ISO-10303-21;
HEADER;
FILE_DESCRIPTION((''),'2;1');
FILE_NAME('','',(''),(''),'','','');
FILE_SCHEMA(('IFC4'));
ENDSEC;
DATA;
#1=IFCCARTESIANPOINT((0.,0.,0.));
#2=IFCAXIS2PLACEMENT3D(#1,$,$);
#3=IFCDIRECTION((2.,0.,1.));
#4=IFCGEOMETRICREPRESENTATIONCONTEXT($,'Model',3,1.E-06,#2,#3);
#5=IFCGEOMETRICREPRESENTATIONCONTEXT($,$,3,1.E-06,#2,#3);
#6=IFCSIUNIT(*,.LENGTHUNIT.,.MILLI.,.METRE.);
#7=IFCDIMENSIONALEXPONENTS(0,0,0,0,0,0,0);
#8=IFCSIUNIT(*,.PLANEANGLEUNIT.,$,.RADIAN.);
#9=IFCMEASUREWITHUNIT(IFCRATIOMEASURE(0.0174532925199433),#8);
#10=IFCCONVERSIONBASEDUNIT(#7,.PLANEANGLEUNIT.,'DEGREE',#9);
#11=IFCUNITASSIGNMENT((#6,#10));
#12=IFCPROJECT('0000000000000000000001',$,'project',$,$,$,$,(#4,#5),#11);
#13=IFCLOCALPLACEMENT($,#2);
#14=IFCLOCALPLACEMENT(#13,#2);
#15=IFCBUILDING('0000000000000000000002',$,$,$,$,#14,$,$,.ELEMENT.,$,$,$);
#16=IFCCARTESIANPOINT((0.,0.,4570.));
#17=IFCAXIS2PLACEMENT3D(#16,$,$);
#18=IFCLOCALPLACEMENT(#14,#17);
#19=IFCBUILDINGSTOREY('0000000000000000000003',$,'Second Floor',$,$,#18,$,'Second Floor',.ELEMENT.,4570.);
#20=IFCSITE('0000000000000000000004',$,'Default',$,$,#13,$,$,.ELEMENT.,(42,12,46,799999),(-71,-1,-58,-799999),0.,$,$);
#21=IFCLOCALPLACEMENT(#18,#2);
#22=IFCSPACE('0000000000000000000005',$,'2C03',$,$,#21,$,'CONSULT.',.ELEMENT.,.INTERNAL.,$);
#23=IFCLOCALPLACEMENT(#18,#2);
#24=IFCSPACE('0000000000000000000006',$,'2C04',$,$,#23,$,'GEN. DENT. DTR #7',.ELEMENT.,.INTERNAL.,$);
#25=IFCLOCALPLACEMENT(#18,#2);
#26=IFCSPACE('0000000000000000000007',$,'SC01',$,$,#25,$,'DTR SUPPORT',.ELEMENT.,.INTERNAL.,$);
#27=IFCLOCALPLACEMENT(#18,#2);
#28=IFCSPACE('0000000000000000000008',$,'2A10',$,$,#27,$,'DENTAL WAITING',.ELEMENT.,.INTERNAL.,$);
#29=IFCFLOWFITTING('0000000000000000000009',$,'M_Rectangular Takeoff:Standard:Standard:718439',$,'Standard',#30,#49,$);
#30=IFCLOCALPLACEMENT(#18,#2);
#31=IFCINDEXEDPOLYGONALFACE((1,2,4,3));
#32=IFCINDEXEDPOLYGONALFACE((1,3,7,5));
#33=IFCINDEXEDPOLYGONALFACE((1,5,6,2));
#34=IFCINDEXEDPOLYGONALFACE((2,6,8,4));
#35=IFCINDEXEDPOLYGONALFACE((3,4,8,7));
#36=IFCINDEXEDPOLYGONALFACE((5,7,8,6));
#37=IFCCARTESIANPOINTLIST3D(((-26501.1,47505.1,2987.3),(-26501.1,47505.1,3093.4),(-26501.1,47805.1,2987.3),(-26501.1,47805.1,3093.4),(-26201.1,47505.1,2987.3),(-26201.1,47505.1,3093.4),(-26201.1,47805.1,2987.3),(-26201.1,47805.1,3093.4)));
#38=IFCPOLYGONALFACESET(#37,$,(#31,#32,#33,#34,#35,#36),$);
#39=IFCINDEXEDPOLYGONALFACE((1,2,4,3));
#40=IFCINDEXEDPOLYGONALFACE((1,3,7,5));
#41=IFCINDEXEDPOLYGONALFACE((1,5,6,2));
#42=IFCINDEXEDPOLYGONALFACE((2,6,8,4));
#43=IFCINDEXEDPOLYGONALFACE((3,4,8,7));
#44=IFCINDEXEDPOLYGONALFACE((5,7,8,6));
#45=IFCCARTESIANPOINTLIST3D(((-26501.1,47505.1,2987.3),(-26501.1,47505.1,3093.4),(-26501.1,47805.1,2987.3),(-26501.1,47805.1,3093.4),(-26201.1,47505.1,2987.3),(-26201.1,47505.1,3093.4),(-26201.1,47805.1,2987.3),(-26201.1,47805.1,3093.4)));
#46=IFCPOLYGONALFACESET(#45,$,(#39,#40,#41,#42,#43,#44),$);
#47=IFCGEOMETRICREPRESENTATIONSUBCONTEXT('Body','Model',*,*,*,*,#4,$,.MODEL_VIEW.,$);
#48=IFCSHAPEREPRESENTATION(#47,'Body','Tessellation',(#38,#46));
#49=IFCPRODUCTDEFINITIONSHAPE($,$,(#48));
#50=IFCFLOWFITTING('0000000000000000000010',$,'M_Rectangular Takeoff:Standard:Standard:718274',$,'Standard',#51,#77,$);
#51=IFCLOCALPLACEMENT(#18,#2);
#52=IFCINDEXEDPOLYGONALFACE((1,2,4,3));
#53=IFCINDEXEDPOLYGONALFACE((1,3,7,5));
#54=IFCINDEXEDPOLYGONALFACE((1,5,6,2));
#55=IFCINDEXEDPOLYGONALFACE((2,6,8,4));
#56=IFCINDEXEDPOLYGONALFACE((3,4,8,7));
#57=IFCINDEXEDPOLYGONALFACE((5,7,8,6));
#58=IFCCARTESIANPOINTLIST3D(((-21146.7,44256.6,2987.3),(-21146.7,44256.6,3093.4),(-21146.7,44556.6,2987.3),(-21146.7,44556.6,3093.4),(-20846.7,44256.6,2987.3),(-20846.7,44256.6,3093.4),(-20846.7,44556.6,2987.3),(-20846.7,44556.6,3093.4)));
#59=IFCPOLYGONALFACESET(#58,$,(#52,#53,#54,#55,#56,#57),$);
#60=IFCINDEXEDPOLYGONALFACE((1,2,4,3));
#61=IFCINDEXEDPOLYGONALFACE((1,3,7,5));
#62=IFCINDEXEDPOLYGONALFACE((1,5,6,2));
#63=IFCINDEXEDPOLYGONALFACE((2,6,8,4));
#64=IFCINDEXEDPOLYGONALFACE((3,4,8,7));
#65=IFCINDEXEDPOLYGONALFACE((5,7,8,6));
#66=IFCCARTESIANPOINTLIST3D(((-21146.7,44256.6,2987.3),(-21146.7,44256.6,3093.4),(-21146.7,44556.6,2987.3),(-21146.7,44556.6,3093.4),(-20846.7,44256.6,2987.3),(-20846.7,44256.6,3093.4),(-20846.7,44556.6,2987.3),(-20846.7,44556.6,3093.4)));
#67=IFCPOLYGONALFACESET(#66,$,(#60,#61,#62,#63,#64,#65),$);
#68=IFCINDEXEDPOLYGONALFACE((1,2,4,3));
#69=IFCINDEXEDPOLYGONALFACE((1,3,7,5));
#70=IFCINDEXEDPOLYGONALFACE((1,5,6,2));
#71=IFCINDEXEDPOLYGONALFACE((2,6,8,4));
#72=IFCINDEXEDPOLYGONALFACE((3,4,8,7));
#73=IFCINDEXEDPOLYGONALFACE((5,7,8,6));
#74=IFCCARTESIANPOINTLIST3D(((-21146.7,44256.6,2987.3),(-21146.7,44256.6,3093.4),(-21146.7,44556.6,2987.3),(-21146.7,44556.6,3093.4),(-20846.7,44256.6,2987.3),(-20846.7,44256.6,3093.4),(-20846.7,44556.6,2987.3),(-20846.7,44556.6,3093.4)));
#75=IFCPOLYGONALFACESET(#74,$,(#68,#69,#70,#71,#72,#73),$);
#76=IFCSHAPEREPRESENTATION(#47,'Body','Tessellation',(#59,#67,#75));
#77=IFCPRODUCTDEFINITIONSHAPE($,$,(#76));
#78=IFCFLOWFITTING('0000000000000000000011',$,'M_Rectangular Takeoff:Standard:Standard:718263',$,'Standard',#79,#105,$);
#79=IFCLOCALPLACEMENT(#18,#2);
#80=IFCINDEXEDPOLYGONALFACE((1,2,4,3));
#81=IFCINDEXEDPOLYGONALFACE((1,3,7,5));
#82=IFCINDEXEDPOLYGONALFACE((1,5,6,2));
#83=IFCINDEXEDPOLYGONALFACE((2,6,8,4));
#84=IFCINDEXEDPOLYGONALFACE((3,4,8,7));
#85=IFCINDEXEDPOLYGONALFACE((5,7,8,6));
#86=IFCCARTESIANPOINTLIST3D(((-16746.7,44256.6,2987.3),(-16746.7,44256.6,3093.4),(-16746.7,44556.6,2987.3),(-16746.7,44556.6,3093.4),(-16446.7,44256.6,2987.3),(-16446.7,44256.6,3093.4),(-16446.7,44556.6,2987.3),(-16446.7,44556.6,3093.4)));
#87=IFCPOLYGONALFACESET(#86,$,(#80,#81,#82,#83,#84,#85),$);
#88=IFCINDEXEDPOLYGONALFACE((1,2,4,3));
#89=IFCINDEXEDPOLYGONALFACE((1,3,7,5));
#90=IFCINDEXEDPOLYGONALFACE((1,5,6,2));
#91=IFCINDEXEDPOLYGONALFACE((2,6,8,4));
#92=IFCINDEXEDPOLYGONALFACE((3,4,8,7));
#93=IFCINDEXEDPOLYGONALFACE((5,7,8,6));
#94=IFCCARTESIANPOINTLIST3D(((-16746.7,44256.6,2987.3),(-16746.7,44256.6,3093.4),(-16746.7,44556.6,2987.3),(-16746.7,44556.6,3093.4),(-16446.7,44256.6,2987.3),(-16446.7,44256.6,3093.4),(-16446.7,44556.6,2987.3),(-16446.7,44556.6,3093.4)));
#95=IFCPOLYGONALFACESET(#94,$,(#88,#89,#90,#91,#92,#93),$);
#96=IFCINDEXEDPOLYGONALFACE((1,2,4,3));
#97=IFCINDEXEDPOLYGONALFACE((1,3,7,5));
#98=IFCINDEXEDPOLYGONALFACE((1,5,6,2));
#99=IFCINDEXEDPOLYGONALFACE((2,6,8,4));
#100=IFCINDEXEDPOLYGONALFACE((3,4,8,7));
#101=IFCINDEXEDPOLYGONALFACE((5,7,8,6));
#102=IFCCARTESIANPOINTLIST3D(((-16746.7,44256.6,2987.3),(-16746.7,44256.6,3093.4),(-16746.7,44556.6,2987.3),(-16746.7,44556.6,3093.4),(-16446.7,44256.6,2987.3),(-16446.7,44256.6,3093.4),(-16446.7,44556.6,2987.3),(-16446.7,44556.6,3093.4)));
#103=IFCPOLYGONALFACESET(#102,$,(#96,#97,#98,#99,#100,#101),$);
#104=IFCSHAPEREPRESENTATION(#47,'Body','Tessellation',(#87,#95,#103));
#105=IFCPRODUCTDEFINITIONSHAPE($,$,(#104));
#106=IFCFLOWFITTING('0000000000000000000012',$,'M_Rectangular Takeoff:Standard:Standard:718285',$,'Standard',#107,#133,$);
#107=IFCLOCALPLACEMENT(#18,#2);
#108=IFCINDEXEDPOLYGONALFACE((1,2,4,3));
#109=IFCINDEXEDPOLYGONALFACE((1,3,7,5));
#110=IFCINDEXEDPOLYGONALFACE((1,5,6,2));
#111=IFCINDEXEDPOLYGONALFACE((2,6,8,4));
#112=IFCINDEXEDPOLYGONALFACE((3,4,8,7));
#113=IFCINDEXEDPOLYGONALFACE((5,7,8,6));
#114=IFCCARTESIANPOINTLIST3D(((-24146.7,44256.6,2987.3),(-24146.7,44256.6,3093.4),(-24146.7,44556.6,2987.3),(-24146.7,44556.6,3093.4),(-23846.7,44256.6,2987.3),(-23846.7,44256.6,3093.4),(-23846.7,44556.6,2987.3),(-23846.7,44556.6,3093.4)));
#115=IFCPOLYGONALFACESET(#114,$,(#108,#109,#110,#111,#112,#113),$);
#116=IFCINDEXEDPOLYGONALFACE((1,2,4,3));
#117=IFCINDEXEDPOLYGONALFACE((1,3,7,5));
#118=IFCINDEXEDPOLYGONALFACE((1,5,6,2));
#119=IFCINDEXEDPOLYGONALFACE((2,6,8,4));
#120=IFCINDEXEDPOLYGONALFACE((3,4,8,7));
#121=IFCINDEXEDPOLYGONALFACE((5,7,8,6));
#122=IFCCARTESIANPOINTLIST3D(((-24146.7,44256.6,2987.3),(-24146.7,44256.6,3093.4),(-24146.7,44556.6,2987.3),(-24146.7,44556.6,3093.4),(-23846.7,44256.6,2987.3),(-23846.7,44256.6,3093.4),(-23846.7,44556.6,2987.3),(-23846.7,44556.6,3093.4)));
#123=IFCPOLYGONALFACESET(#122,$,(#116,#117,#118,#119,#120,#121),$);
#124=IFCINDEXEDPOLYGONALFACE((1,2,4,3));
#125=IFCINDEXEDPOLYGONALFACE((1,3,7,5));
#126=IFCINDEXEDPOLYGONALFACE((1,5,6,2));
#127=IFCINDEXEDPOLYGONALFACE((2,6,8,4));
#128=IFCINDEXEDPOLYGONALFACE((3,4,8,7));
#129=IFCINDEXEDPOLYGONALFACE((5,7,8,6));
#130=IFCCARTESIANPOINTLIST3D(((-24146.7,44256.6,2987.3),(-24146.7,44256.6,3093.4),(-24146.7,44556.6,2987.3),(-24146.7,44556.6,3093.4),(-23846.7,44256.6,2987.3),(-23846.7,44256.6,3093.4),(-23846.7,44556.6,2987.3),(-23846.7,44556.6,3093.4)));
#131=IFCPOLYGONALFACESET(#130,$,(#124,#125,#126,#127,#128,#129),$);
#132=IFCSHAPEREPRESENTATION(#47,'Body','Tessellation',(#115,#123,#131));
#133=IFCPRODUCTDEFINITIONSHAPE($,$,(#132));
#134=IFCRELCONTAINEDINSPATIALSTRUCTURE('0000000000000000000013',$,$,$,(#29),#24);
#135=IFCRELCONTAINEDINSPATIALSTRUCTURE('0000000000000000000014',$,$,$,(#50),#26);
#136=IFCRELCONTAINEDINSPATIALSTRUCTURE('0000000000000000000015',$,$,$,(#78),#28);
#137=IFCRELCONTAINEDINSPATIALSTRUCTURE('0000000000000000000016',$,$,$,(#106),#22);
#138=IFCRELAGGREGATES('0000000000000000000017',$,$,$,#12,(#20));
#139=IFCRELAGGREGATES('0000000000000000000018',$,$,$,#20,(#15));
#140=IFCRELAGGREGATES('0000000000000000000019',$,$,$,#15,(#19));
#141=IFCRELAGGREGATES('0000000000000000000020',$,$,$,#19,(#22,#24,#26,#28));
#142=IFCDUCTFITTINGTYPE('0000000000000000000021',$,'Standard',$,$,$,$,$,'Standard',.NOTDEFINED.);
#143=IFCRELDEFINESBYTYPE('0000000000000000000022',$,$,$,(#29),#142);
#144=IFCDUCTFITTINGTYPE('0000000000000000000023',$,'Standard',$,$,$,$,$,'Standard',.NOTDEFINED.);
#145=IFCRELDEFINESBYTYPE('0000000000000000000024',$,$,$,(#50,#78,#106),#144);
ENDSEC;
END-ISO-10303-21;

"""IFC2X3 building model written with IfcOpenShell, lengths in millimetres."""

from ifc_helpers import new_model, entity, si_unit, converted_unit, direction, frame, frame_2d, origin, place, context, subcontext, project, spatial, rectangle, extrude, source, transform, mapped, type_object, type_shapes, element, save


model = new_model("IFC2X3")

# Units and contexts
model_context = context("Model", 3, precision=1e-06, world=origin(), true_north=direction((2.0, 0.0, 1.0)))
context_of_model = context(None, 3, precision=1e-06, world=origin(), true_north=direction((2.0, 0.0, 1.0)))
body_context = subcontext(model_context, "Body", "Model", "MODEL_VIEW")
ifc_project = project(units=[si_unit("LENGTHUNIT", "METRE", prefix="MILLI"), converted_unit("PLANEANGLEUNIT", "DEGREE", entity("IfcRatioMeasure", 0.0174532925199433), si_unit("PLANEANGLEUNIT", "RADIAN"), dimensions=[0, 0, 0, 0, 0, 0, 0])], contexts=[model_context, context_of_model])

# Site, building, storey
site_placement = place(None, origin())
site = spatial("IfcSite", under=ifc_project, at=site_placement, Name="Default", CompositionType="ELEMENT", RefLatitude=(42, 12, 46, 799999), RefLongitude=(-71, -1, -58, -799999), RefElevation=0.0)
building_placement = place(site_placement, origin())
building = spatial("IfcBuilding", under=site, at=building_placement, CompositionType="ELEMENT")
storey_placement = place(building_placement, frame((0.0, 0.0, 4570.0)))
storey = spatial("IfcBuildingStorey", under=building, at=storey_placement, Name="Second Floor", LongName="Second Floor", CompositionType="ELEMENT", Elevation=4570.0)

# Shared definitions
space_1_placement = place(storey_placement, origin())
space_1 = spatial("IfcSpace", under=storey, at=space_1_placement, Name="2C03", LongName="CONSULT.", CompositionType="ELEMENT", InteriorOrExteriorSpace="INTERNAL")

# Shared definitions
duct_fitting_type_1 = type_object("IfcDuctFittingType", Name="Standard", ElementType="Standard", PredefinedType="NOTDEFINED")
shared_shape_1 = source(origin(), body_context, "Body", "SweptSolid", [
    extrude(rectangle(XDim=300.0, YDim=106.1, at=frame_2d((0.0, 0.0), x_axis=(1.0, 0.0))), frame((47.0, 0.0, -150.0), z_axis=(0.0, 0.0, 1.0), x_axis=(0.0, -1.0, 0.0)), (0.0, 0.0, 1.0), 300.0),
    extrude(rectangle(XDim=300.0, YDim=106.1, at=frame_2d((0.0, 0.0), x_axis=(1.0, 0.0))), frame((47.0, 0.0, -150.0), z_axis=(0.0, 0.0, 1.0), x_axis=(0.0, -1.0, 0.0)), (0.0, 0.0, 1.0), 300.0),
])
type_shapes(duct_fitting_type_1, [shared_shape_1])

# Shared definitions
space_2_placement = place(storey_placement, origin())
space_2 = spatial("IfcSpace", under=storey, at=space_2_placement, Name="2C04", LongName="GEN. DENT. DTR #7", CompositionType="ELEMENT", InteriorOrExteriorSpace="INTERNAL")

# Flow fitting
flow_fitting_1_placement = place(space_2_placement, frame((-26351.1, 47655.1, 3087.3), z_axis=(0.0, -1.0, 0.0), x_axis=(0.0, 0.0, -1.0)))
element("IfcFlowFitting", 1, at=flow_fitting_1_placement, inside=space_2, type_object=duct_fitting_type_1, Name="M_Rectangular Takeoff:Standard:Standard:718439", ObjectType="Standard", context=body_context, shape_type="MappedRepresentation", body=[
    mapped(shared_shape_1, transform((0.0, 0.0, 0.0), scale=1.0)),
])

# Shared definitions
space_3_placement = place(storey_placement, origin())
space_3 = spatial("IfcSpace", under=storey, at=space_3_placement, Name="SC01", LongName="DTR SUPPORT", CompositionType="ELEMENT", InteriorOrExteriorSpace="INTERNAL")

# Flow fitting
duct_fitting_type_2 = type_object("IfcDuctFittingType", Name="Standard", ElementType="Standard", PredefinedType="NOTDEFINED")
shared_shape_2 = source(origin(), body_context, "Body", "SweptSolid", [
    extrude(rectangle(XDim=106.1, YDim=300.0, at=frame_2d((0.0, 0.0), x_axis=(1.0, 0.0))), frame((47.0, 0.0, -150.0)), (0.0, 0.0, 1.0), 300.0),
    extrude(rectangle(XDim=106.1, YDim=300.0, at=frame_2d((0.0, 0.0), x_axis=(1.0, 0.0))), frame((47.0, 0.0, -150.0)), (0.0, 0.0, 1.0), 300.0),
    extrude(rectangle(XDim=106.1, YDim=300.0, at=frame_2d((0.0, 0.0), x_axis=(1.0, 0.0))), frame((47.0, 0.0, -150.0)), (0.0, 0.0, 1.0), 300.0),
])
type_shapes(duct_fitting_type_2, [shared_shape_2])
flow_fitting_2_placement = place(space_3_placement, frame((-20996.7, 44406.6, 3087.3), z_axis=(0.0, -1.0, 0.0), x_axis=(0.0, 0.0, -1.0)))
element("IfcFlowFitting", 2, at=flow_fitting_2_placement, inside=space_3, type_object=duct_fitting_type_2, Name="M_Rectangular Takeoff:Standard:Standard:718274", ObjectType="Standard", context=body_context, shape_type="MappedRepresentation", body=[
    mapped(shared_shape_2, transform((0.0, 0.0, 0.0), scale=1.0)),
])

# Shared definitions
space_4_placement = place(storey_placement, origin())
space_4 = spatial("IfcSpace", under=storey, at=space_4_placement, Name="2A10", LongName="DENTAL WAITING", CompositionType="ELEMENT", InteriorOrExteriorSpace="INTERNAL")

# Flow fittings
flow_fitting_3_placement = place(space_4_placement, frame((-16596.7, 44406.6, 3087.3), z_axis=(0.0, -1.0, 0.0), x_axis=(0.0, 0.0, -1.0)))
element("IfcFlowFitting", 3, at=flow_fitting_3_placement, inside=space_4, type_object=duct_fitting_type_2, Name="M_Rectangular Takeoff:Standard:Standard:718263", ObjectType="Standard", context=body_context, shape_type="MappedRepresentation", body=[
    mapped(shared_shape_2, transform((0.0, 0.0, 0.0), scale=1.0)),
])
flow_fitting_4_placement = place(space_1_placement, frame((-23996.7, 44406.6, 3087.3), z_axis=(0.0, -1.0, 0.0), x_axis=(0.0, 0.0, -1.0)))
element("IfcFlowFitting", 4, at=flow_fitting_4_placement, inside=space_1, type_object=duct_fitting_type_2, Name="M_Rectangular Takeoff:Standard:Standard:718285", ObjectType="Standard", context=body_context, shape_type="MappedRepresentation", body=[
    mapped(shared_shape_2, transform((0.0, 0.0, 0.0), scale=1.0)),
])

save(model, "model.ifc")
